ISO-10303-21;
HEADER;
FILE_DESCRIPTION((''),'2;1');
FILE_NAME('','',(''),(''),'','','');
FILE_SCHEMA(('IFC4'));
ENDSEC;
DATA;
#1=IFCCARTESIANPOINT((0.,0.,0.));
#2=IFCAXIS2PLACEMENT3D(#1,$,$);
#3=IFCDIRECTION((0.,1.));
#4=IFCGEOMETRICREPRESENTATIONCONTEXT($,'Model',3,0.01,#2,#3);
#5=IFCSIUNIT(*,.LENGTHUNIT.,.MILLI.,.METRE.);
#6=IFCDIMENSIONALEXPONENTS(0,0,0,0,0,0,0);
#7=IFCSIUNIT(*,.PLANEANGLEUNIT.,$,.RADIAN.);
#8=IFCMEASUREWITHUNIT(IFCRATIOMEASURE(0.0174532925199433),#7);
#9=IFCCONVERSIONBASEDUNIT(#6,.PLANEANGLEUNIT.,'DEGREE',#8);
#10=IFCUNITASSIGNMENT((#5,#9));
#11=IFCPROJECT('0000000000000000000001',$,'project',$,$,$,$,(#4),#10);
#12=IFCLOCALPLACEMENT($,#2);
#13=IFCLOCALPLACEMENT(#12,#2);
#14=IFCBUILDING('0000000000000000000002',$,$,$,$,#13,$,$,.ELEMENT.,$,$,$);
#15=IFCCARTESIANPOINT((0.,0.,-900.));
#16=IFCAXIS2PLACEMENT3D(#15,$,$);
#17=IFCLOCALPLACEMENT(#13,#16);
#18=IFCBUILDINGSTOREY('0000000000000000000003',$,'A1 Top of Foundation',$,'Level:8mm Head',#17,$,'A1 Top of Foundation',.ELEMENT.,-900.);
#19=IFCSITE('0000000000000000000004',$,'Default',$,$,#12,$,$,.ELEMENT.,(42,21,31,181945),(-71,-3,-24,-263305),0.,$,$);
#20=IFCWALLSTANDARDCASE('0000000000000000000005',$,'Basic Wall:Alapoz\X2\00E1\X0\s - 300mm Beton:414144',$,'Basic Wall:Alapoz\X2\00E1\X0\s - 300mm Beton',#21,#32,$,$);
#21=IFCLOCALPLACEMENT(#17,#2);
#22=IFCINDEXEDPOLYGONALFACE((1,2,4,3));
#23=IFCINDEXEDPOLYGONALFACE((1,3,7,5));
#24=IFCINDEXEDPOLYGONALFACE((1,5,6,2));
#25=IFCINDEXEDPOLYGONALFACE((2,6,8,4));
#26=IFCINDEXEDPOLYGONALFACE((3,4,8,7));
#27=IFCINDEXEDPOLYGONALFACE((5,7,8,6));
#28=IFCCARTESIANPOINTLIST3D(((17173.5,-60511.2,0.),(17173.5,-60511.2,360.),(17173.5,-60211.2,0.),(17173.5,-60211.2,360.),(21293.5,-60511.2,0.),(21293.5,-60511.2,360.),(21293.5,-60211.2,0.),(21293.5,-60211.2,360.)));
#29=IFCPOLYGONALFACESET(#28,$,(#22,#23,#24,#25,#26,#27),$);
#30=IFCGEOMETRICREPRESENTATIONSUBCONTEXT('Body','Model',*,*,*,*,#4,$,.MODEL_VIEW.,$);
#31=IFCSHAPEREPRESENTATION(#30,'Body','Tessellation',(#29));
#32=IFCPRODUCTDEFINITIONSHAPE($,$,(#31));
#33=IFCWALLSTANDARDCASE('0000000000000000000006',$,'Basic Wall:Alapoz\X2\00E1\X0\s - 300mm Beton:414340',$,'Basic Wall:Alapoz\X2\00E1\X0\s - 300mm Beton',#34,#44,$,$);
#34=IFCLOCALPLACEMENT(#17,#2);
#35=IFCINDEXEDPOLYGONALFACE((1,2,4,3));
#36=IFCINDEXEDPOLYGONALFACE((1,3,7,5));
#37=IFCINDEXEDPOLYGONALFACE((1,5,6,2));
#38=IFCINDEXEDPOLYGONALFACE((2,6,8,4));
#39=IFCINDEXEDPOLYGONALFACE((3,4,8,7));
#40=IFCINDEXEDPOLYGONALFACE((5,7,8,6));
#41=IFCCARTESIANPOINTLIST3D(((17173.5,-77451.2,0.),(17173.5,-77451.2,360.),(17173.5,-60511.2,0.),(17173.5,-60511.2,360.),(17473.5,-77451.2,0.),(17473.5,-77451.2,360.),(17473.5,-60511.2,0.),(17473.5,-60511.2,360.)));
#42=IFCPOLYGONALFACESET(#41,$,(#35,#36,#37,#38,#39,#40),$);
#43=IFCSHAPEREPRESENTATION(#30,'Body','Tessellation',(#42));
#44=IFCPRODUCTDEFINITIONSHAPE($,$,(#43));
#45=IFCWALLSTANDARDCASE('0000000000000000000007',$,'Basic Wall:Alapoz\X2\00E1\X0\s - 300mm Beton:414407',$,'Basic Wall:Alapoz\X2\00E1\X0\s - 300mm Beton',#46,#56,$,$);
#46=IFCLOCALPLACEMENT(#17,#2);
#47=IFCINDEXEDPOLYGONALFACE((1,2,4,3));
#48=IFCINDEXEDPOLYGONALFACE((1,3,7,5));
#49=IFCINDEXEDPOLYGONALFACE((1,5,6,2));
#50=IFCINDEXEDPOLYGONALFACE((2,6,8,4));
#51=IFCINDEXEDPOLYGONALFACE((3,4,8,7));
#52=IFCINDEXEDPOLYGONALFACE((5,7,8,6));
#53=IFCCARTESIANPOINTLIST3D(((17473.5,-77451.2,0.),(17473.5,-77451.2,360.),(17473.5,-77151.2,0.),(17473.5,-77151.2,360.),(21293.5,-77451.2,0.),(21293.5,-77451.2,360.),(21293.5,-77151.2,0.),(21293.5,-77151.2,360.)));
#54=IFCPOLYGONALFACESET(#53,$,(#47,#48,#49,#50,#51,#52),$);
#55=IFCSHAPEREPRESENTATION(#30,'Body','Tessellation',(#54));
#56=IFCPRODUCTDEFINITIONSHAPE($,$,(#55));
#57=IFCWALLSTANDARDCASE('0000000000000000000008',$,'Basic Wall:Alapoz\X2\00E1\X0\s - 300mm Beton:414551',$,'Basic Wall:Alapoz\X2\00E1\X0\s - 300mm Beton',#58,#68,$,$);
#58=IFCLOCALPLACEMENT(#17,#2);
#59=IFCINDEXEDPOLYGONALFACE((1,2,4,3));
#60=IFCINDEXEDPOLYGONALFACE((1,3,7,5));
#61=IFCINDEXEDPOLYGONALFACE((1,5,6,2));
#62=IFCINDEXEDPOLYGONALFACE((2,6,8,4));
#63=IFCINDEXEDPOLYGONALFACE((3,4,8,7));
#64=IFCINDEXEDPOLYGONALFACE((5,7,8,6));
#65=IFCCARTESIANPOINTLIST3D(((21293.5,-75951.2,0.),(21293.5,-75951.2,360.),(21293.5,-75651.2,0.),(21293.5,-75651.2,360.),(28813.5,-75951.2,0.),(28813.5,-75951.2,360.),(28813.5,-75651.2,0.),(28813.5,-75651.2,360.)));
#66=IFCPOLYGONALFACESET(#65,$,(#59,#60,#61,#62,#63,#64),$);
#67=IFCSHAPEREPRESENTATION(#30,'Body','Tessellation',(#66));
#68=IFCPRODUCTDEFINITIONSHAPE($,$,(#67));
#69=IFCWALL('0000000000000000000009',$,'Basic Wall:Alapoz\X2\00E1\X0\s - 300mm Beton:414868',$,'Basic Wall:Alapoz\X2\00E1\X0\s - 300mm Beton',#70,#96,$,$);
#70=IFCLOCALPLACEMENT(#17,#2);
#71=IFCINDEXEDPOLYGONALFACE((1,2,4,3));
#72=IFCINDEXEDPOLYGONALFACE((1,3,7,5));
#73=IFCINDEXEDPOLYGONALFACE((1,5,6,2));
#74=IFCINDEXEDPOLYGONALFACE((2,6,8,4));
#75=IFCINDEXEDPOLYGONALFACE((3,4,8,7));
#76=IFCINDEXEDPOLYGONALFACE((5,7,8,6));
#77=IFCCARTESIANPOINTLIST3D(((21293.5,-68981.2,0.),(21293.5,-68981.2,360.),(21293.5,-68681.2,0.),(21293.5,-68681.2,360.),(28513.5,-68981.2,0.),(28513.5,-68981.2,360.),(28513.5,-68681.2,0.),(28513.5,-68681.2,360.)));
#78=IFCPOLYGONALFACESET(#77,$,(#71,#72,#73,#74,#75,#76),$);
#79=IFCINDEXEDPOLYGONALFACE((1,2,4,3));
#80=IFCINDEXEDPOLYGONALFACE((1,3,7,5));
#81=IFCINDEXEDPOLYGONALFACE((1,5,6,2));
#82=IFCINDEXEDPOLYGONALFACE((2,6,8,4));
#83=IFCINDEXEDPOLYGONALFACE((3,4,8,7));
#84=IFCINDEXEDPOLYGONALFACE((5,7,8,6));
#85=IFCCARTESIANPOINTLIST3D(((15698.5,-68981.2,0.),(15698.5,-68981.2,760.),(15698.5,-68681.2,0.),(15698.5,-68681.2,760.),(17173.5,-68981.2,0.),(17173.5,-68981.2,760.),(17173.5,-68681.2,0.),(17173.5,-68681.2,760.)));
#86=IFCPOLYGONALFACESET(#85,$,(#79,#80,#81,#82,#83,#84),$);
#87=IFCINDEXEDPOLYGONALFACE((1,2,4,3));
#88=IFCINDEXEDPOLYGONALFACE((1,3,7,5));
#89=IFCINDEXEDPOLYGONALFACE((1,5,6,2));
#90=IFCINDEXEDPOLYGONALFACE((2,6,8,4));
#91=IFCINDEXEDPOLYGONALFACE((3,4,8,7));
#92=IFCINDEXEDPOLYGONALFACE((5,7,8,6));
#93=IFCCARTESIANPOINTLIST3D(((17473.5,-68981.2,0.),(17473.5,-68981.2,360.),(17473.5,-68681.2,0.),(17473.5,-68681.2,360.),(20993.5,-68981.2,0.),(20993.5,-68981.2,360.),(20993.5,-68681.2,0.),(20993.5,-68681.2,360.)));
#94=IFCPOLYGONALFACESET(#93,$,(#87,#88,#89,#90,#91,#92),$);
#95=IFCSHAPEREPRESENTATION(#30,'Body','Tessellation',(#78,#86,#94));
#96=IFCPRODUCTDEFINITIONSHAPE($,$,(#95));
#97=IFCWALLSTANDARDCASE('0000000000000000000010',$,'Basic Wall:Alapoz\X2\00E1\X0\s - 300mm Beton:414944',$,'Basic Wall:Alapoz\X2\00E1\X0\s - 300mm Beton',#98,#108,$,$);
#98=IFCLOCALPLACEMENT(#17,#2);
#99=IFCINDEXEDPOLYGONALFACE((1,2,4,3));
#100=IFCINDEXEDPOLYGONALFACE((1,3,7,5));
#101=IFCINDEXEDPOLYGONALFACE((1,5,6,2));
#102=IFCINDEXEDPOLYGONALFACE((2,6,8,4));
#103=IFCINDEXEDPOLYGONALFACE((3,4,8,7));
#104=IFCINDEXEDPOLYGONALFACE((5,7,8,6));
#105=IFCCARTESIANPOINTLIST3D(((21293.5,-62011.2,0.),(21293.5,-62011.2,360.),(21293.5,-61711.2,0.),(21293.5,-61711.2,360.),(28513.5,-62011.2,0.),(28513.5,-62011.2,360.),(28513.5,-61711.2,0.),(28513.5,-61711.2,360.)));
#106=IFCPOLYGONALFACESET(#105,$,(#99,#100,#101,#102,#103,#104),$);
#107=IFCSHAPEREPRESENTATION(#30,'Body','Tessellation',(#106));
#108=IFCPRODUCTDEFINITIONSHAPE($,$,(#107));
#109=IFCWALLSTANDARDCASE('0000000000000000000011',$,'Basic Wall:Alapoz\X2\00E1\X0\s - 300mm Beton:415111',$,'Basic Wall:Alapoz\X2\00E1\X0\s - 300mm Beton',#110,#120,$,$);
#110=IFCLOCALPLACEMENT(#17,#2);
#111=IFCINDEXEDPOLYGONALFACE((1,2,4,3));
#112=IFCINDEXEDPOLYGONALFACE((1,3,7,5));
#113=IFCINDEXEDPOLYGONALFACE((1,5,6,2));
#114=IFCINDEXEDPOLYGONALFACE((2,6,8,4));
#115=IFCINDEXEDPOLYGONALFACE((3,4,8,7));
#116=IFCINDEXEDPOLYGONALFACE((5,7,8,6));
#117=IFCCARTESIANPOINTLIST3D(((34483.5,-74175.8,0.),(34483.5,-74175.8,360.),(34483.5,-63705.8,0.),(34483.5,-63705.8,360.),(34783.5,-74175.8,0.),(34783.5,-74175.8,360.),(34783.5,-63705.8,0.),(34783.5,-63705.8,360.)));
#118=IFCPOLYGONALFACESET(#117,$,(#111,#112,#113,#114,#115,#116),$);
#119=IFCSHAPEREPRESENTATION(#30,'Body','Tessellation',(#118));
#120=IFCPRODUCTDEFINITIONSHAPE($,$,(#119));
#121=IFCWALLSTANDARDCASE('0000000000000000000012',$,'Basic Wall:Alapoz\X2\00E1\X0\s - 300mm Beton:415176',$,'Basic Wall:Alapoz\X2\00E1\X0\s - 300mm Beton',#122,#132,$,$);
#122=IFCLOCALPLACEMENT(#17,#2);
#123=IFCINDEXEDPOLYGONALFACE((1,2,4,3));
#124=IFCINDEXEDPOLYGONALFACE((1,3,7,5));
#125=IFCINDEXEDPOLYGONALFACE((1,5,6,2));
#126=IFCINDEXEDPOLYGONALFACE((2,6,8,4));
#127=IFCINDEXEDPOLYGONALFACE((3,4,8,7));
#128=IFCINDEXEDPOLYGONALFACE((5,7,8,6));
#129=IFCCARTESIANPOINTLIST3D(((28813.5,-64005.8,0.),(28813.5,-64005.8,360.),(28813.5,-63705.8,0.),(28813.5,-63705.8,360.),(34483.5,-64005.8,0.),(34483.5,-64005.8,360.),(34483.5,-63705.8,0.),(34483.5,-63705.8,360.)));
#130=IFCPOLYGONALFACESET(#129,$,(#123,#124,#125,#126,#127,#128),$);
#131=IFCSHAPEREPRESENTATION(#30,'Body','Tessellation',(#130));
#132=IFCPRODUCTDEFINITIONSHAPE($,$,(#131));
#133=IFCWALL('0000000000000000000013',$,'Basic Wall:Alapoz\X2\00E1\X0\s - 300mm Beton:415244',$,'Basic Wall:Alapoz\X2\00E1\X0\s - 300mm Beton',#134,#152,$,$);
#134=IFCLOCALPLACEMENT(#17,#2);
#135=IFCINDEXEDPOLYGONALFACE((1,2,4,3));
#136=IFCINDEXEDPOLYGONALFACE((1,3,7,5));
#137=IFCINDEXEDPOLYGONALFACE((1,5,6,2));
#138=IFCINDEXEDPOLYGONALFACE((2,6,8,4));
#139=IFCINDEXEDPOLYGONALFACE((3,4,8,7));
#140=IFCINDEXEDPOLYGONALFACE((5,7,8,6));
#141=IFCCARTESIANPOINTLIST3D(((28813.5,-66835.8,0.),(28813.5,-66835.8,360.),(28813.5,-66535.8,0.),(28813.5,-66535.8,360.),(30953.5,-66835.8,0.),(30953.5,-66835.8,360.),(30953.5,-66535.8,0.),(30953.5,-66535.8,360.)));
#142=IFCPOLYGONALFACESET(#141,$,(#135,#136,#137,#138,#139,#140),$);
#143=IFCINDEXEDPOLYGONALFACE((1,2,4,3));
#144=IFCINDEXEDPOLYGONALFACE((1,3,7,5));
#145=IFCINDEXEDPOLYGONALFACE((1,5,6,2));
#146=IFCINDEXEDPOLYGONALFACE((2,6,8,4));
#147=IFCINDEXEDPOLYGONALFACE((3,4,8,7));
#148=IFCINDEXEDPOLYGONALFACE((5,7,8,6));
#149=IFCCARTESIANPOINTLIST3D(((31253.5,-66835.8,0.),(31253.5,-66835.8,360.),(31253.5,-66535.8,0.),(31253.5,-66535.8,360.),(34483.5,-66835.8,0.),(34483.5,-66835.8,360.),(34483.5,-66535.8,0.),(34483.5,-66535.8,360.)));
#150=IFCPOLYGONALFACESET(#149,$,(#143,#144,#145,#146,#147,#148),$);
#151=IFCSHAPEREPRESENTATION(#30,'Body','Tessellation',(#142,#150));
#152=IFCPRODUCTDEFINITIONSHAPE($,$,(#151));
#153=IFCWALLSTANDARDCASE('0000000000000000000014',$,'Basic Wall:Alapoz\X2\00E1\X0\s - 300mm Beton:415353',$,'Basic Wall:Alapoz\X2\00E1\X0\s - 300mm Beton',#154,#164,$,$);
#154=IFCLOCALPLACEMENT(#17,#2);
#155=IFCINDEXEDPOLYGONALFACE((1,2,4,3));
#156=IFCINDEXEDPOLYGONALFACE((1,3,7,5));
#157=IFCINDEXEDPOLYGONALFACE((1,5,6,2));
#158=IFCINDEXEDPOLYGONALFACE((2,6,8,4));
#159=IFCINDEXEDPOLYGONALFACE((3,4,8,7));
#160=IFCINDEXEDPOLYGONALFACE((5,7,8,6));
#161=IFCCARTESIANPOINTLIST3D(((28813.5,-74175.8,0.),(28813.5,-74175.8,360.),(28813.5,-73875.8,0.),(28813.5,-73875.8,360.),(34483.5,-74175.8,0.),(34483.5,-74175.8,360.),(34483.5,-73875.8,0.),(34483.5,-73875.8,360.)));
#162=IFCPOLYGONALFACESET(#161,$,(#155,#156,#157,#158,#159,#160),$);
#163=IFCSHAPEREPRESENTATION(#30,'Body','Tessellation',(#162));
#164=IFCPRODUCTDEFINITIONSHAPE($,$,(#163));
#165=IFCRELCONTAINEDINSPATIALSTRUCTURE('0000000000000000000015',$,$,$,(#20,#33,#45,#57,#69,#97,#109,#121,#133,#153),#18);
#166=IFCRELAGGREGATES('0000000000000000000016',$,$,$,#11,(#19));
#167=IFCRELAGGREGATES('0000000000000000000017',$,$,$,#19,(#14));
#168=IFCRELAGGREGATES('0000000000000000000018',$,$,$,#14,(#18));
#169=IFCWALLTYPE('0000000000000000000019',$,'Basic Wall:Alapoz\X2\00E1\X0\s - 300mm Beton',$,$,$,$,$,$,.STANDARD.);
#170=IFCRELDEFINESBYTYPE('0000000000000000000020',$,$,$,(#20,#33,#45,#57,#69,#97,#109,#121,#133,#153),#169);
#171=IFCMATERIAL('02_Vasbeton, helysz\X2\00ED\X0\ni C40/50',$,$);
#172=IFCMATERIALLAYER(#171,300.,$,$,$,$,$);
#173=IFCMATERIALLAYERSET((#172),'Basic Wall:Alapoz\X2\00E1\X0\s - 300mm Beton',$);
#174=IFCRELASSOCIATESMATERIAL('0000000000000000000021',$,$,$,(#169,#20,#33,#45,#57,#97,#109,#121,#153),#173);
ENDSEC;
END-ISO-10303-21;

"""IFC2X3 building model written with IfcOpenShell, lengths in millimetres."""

from ifc_helpers import new_model, entity, si_unit, converted_unit, direction, frame, frame_2d, origin, place, context, subcontext, project, spatial, polyline, rectangle, extrude, clip, bounded_halfspace, material, layer, layer_set, layer_usage, type_object, element, save


model = new_model("IFC2X3")

# Units and contexts
model_context = context("Model", 3, precision=0.01, world=origin(), true_north=direction((0.0, 1.0)))
body_context = subcontext(model_context, "Body", "Model", "MODEL_VIEW")
ifc_project = project(units=[si_unit("LENGTHUNIT", "METRE", prefix="MILLI"), converted_unit("PLANEANGLEUNIT", "DEGREE", entity("IfcRatioMeasure", 0.0174532925199433), si_unit("PLANEANGLEUNIT", "RADIAN"), dimensions=[0, 0, 0, 0, 0, 0, 0])], contexts=[model_context])

# Site, building, storey
site_placement = place(None, origin())
site = spatial("IfcSite", under=ifc_project, at=site_placement, Name="Default", CompositionType="ELEMENT", RefLatitude=(42, 21, 31, 181945), RefLongitude=(-71, -3, -24, -263305), RefElevation=0.0)
building_placement = place(site_placement, origin())
building = spatial("IfcBuilding", under=site, at=building_placement, CompositionType="ELEMENT")
storey_placement = place(building_placement, frame((0.0, 0.0, -900.0)))
storey = spatial("IfcBuildingStorey", under=building, at=storey_placement, Name="A1 Top of Foundation", ObjectType="Level:8mm Head", LongName="A1 Top of Foundation", CompositionType="ELEMENT", Elevation=-900.0)

# Walls
ifc_material = material(Name="02_Vasbeton, helyszíni C40/50")
ifc_layer = layer(ifc_material, 300.0)
ifc_layer_set = layer_set([ifc_layer], Name="Basic Wall:Alapozás - 300mm Beton")
ifc_layer_usage_1 = layer_usage(ifc_layer_set, "AXIS2", "NEGATIVE", 150.0)
wall_type = type_object("IfcWallType", Name="Basic Wall:Alapozás - 300mm Beton", PredefinedType="STANDARD", material=ifc_layer_set)
wall_1_placement = place(storey_placement, frame((21293.5, -60361.2, 0.0), z_axis=(0.0, 0.0, 1.0), x_axis=(-1.0, 0.0, 0.0)))
element("IfcWallStandardCase", 1, at=wall_1_placement, inside=storey, type_object=wall_type, material=ifc_layer_usage_1, Name="Basic Wall:Alapozás - 300mm Beton:414144", ObjectType="Basic Wall:Alapozás - 300mm Beton", context=body_context, shape_type="Clipping", body=[
    clip(extrude(rectangle(XDim=4120.0, YDim=300.0, at=frame_2d((2060.0, 0.0), x_axis=(-1.0, 0.0))), origin(), (0.0, 0.0, 1.0), 360.0), bounded_halfspace(frame((0.0, -150.0, 360.0), z_axis=(0.0, 0.0, -1.0), x_axis=(-1.0, 0.0, 0.0)), True, frame((0.0, -150.0, 360.0), z_axis=(0.0, 0.0, -1.0), x_axis=(-1.0, 0.0, 0.0)), polyline([(0.0, 0.0), (0.0, 300.0), (-300.0, 300.0), (-3820.0, 300.0), (-4120.0, 300.0), (-4120.0, 0.0), (0.0, 0.0)]))),
])
ifc_layer_usage_2 = layer_usage(ifc_layer_set, "AXIS2", "NEGATIVE", 150.0)
wall_2_placement = place(storey_placement, frame((17323.5, -60511.2, 0.0), z_axis=(0.0, 0.0, 1.0), x_axis=(0.0, -1.0, 0.0)))
element("IfcWallStandardCase", 2, at=wall_2_placement, inside=storey, type_object=wall_type, material=ifc_layer_usage_2, Name="Basic Wall:Alapozás - 300mm Beton:414340", ObjectType="Basic Wall:Alapozás - 300mm Beton", context=body_context, shape_type="Clipping", body=[
    clip(extrude(rectangle(XDim=16940.0, YDim=300.0, at=frame_2d((8470.0, 0.0), x_axis=(-1.0, 0.0))), origin(), (0.0, 0.0, 1.0), 360.0), bounded_halfspace(frame((0.0, -150.0, 360.0), z_axis=(0.0, 0.0, -1.0), x_axis=(0.0, 1.0, 0.0)), True, frame((0.0, -150.0, 360.0), z_axis=(0.0, 0.0, -1.0), x_axis=(0.0, 1.0, 0.0)), polyline([(0.0, 0.0), (300.0, 0.0), (300.0, 8170.0), (300.0, 8470.0), (300.0, 16640.0), (300.0, 16940.0), (0.0, 16940.0), (0.0, 0.0)]))),
])
ifc_layer_usage_3 = layer_usage(ifc_layer_set, "AXIS2", "NEGATIVE", 150.0)
wall_3_placement = place(storey_placement, frame((17473.5, -77301.2, 0.0)))
element("IfcWallStandardCase", 3, at=wall_3_placement, inside=storey, type_object=wall_type, material=ifc_layer_usage_3, Name="Basic Wall:Alapozás - 300mm Beton:414407", ObjectType="Basic Wall:Alapozás - 300mm Beton", context=body_context, shape_type="Clipping", body=[
    clip(extrude(rectangle(XDim=3820.0, YDim=300.0, at=frame_2d((1910.0, 0.0), x_axis=(-1.0, 0.0))), origin(), (0.0, 0.0, 1.0), 360.0), bounded_halfspace(frame((0.0, -150.0, 360.0), z_axis=(0.0, 0.0, -1.0), x_axis=(1.0, 0.0, 0.0)), True, frame((0.0, -150.0, 360.0), z_axis=(0.0, 0.0, -1.0), x_axis=(1.0, 0.0, 0.0)), polyline([(0.0, 0.0), (0.0, -300.0), (3520.0, -300.0), (3820.0, -300.0), (3820.0, 0.0), (0.0, 0.0)]))),
])
ifc_layer_usage_4 = layer_usage(ifc_layer_set, "AXIS2", "NEGATIVE", 150.0)
wall_4_placement = place(storey_placement, frame((21293.5, -75801.2, 0.0)))
element("IfcWallStandardCase", 4, at=wall_4_placement, inside=storey, type_object=wall_type, material=ifc_layer_usage_4, Name="Basic Wall:Alapozás - 300mm Beton:414551", ObjectType="Basic Wall:Alapozás - 300mm Beton", context=body_context, shape_type="Clipping", body=[
    clip(extrude(rectangle(XDim=7520.0, YDim=300.0, at=frame_2d((3760.0, 0.0), x_axis=(-1.0, 0.0))), origin(), (0.0, 0.0, 1.0), 360.0), bounded_halfspace(frame((0.0, -150.0, 360.0), z_axis=(0.0, 0.0, -1.0), x_axis=(1.0, 0.0, 0.0)), True, frame((0.0, -150.0, 360.0), z_axis=(0.0, 0.0, -1.0), x_axis=(1.0, 0.0, 0.0)), polyline([(0.0, 0.0), (0.0, -300.0), (7220.0, -300.0), (7520.0, -300.0), (7520.0, 0.0), (0.0, 0.0)]))),
])
wall_5_placement = place(storey_placement, frame((28513.5, -68831.2, 0.0), z_axis=(0.0, 0.0, 1.0), x_axis=(-1.0, 0.0, 0.0)))
element("IfcWall", 5, at=wall_5_placement, inside=storey, type_object=wall_type, Name="Basic Wall:Alapozás - 300mm Beton:414868", ObjectType="Basic Wall:Alapozás - 300mm Beton", context=body_context, shape_type="SweptSolid", body=[
    extrude(rectangle(XDim=7220.0, YDim=300.0, at=frame_2d((0.0, 0.0), x_axis=(1.0, 0.0))), frame((3610.0, 0.0, 0.0)), (0.0, 0.0, 1.0), 360.0),
    extrude(rectangle(XDim=300.0, YDim=1475.0, at=frame_2d((0.0, 0.0), x_axis=(1.0, 0.0))), frame((12077.5, 0.0, 0.0), z_axis=(0.0, 0.0, 1.0), x_axis=(0.0, 1.0, 0.0)), (0.0, 0.0, 1.0), 760.0),
    extrude(rectangle(XDim=3520.0, YDim=300.0, at=frame_2d((0.0, 0.0), x_axis=(1.0, 0.0))), frame((9280.0, 0.0, 0.0), z_axis=(0.0, 0.0, 1.0), x_axis=(-1.0, 0.0, 0.0)), (0.0, 0.0, 1.0), 360.0),
])
ifc_layer_usage_5 = layer_usage(ifc_layer_set, "AXIS2", "POSITIVE", -150.0)
wall_6_placement = place(storey_placement, frame((21293.5, -61861.2, 0.0)))
element("IfcWallStandardCase", 6, at=wall_6_placement, inside=storey, type_object=wall_type, material=ifc_layer_usage_5, Name="Basic Wall:Alapozás - 300mm Beton:414944", ObjectType="Basic Wall:Alapozás - 300mm Beton", context=body_context, shape_type="Clipping", body=[
    clip(extrude(rectangle(XDim=7220.0, YDim=300.0, at=frame_2d((3610.0, 0.0), x_axis=(-1.0, 0.0))), origin(), (0.0, 0.0, 1.0), 360.0), bounded_halfspace(frame((0.0, -150.0, 360.0), z_axis=(0.0, 0.0, -1.0), x_axis=(1.0, 0.0, 0.0)), True, frame((0.0, -150.0, 360.0), z_axis=(0.0, 0.0, -1.0), x_axis=(1.0, 0.0, 0.0)), polyline([(0.0, 0.0), (0.0, -300.0), (7220.0, -300.0), (7220.0, 0.0), (0.0, 0.0)]))),
])
ifc_layer_usage_6 = layer_usage(ifc_layer_set, "AXIS2", "NEGATIVE", 150.0)
wall_7_placement = place(storey_placement, frame((34633.5, -74175.8, 0.0), z_axis=(0.0, 0.0, 1.0), x_axis=(0.0, 1.0, 0.0)))
element("IfcWallStandardCase", 7, at=wall_7_placement, inside=storey, type_object=wall_type, material=ifc_layer_usage_6, Name="Basic Wall:Alapozás - 300mm Beton:415111", ObjectType="Basic Wall:Alapozás - 300mm Beton", context=body_context, shape_type="Clipping", body=[
    clip(extrude(rectangle(XDim=10470.0, YDim=300.0, at=frame_2d((5235.0, 0.0), x_axis=(-1.0, 0.0))), origin(), (0.0, 0.0, 1.0), 360.0), bounded_halfspace(frame((0.0, -150.0, 360.0), z_axis=(0.0, 0.0, -1.0), x_axis=(-1.0, 0.0, 0.0)), True, frame((0.0, -150.0, 360.0), z_axis=(0.0, 0.0, -1.0), x_axis=(-1.0, 0.0, 0.0)), polyline([(0.0, 0.0), (0.0, 300.0), (-10170.0, 300.0), (-10470.0, 300.0), (-10470.0, 0.0), (0.0, 0.0)]))),
])
ifc_layer_usage_7 = layer_usage(ifc_layer_set, "AXIS2", "POSITIVE", -150.0)
wall_8_placement = place(storey_placement, frame((28813.5, -63855.8, 0.0)))
element("IfcWallStandardCase", 8, at=wall_8_placement, inside=storey, type_object=wall_type, material=ifc_layer_usage_7, Name="Basic Wall:Alapozás - 300mm Beton:415176", ObjectType="Basic Wall:Alapozás - 300mm Beton", context=body_context, shape_type="Clipping", body=[
    clip(extrude(rectangle(XDim=5670.0, YDim=300.0, at=frame_2d((2835.0, 0.0), x_axis=(-1.0, 0.0))), origin(), (0.0, 0.0, 1.0), 360.0), bounded_halfspace(frame((0.0, -150.0, 360.0), z_axis=(0.0, 0.0, -1.0), x_axis=(0.0, -1.0, 0.0)), True, frame((0.0, -150.0, 360.0), z_axis=(0.0, 0.0, -1.0), x_axis=(0.0, -1.0, 0.0)), polyline([(0.0, 0.0), (-300.0, 0.0), (-300.0, -5670.0), (0.0, -5670.0), (0.0, -2440.0), (0.0, -2140.0), (0.0, 0.0)]))),
])
wall_9_placement = place(storey_placement, frame((28813.5, -66685.8, 0.0)))
element("IfcWall", 9, at=wall_9_placement, inside=storey, type_object=wall_type, Name="Basic Wall:Alapozás - 300mm Beton:415244", ObjectType="Basic Wall:Alapozás - 300mm Beton", context=body_context, shape_type="SweptSolid", body=[
    extrude(rectangle(XDim=2140.0, YDim=300.0, at=frame_2d((0.0, 0.0), x_axis=(1.0, 0.0))), frame((1070.0, 0.0, 0.0), z_axis=(0.0, 0.0, 1.0), x_axis=(-1.0, 0.0, 0.0)), (0.0, 0.0, 1.0), 360.0),
    extrude(rectangle(XDim=3230.0, YDim=300.0, at=frame_2d((0.0, 0.0), x_axis=(1.0, 0.0))), frame((4055.0, 0.0, 0.0)), (0.0, 0.0, 1.0), 360.0),
])
ifc_layer_usage_8 = layer_usage(ifc_layer_set, "AXIS2", "NEGATIVE", 150.0)
wall_10_placement = place(storey_placement, frame((28813.5, -74025.8, 0.0)))
element("IfcWallStandardCase", 10, at=wall_10_placement, inside=storey, type_object=wall_type, material=ifc_layer_usage_8, Name="Basic Wall:Alapozás - 300mm Beton:415353", ObjectType="Basic Wall:Alapozás - 300mm Beton", context=body_context, shape_type="Clipping", body=[
    clip(extrude(rectangle(XDim=5670.0, YDim=300.0, at=frame_2d((2835.0, 0.0), x_axis=(-1.0, 0.0))), origin(), (0.0, 0.0, 1.0), 360.0), bounded_halfspace(frame((0.0, -150.0, 360.0), z_axis=(0.0, 0.0, -1.0), x_axis=(0.0, -1.0, 0.0)), True, frame((0.0, -150.0, 360.0), z_axis=(0.0, 0.0, -1.0), x_axis=(0.0, -1.0, 0.0)), polyline([(0.0, 0.0), (-300.0, 0.0), (-300.0, -2140.0), (-300.0, -2440.0), (-300.0, -5670.0), (0.0, -5670.0), (0.0, 0.0)]))),
])

save(model, "model.ifc")
